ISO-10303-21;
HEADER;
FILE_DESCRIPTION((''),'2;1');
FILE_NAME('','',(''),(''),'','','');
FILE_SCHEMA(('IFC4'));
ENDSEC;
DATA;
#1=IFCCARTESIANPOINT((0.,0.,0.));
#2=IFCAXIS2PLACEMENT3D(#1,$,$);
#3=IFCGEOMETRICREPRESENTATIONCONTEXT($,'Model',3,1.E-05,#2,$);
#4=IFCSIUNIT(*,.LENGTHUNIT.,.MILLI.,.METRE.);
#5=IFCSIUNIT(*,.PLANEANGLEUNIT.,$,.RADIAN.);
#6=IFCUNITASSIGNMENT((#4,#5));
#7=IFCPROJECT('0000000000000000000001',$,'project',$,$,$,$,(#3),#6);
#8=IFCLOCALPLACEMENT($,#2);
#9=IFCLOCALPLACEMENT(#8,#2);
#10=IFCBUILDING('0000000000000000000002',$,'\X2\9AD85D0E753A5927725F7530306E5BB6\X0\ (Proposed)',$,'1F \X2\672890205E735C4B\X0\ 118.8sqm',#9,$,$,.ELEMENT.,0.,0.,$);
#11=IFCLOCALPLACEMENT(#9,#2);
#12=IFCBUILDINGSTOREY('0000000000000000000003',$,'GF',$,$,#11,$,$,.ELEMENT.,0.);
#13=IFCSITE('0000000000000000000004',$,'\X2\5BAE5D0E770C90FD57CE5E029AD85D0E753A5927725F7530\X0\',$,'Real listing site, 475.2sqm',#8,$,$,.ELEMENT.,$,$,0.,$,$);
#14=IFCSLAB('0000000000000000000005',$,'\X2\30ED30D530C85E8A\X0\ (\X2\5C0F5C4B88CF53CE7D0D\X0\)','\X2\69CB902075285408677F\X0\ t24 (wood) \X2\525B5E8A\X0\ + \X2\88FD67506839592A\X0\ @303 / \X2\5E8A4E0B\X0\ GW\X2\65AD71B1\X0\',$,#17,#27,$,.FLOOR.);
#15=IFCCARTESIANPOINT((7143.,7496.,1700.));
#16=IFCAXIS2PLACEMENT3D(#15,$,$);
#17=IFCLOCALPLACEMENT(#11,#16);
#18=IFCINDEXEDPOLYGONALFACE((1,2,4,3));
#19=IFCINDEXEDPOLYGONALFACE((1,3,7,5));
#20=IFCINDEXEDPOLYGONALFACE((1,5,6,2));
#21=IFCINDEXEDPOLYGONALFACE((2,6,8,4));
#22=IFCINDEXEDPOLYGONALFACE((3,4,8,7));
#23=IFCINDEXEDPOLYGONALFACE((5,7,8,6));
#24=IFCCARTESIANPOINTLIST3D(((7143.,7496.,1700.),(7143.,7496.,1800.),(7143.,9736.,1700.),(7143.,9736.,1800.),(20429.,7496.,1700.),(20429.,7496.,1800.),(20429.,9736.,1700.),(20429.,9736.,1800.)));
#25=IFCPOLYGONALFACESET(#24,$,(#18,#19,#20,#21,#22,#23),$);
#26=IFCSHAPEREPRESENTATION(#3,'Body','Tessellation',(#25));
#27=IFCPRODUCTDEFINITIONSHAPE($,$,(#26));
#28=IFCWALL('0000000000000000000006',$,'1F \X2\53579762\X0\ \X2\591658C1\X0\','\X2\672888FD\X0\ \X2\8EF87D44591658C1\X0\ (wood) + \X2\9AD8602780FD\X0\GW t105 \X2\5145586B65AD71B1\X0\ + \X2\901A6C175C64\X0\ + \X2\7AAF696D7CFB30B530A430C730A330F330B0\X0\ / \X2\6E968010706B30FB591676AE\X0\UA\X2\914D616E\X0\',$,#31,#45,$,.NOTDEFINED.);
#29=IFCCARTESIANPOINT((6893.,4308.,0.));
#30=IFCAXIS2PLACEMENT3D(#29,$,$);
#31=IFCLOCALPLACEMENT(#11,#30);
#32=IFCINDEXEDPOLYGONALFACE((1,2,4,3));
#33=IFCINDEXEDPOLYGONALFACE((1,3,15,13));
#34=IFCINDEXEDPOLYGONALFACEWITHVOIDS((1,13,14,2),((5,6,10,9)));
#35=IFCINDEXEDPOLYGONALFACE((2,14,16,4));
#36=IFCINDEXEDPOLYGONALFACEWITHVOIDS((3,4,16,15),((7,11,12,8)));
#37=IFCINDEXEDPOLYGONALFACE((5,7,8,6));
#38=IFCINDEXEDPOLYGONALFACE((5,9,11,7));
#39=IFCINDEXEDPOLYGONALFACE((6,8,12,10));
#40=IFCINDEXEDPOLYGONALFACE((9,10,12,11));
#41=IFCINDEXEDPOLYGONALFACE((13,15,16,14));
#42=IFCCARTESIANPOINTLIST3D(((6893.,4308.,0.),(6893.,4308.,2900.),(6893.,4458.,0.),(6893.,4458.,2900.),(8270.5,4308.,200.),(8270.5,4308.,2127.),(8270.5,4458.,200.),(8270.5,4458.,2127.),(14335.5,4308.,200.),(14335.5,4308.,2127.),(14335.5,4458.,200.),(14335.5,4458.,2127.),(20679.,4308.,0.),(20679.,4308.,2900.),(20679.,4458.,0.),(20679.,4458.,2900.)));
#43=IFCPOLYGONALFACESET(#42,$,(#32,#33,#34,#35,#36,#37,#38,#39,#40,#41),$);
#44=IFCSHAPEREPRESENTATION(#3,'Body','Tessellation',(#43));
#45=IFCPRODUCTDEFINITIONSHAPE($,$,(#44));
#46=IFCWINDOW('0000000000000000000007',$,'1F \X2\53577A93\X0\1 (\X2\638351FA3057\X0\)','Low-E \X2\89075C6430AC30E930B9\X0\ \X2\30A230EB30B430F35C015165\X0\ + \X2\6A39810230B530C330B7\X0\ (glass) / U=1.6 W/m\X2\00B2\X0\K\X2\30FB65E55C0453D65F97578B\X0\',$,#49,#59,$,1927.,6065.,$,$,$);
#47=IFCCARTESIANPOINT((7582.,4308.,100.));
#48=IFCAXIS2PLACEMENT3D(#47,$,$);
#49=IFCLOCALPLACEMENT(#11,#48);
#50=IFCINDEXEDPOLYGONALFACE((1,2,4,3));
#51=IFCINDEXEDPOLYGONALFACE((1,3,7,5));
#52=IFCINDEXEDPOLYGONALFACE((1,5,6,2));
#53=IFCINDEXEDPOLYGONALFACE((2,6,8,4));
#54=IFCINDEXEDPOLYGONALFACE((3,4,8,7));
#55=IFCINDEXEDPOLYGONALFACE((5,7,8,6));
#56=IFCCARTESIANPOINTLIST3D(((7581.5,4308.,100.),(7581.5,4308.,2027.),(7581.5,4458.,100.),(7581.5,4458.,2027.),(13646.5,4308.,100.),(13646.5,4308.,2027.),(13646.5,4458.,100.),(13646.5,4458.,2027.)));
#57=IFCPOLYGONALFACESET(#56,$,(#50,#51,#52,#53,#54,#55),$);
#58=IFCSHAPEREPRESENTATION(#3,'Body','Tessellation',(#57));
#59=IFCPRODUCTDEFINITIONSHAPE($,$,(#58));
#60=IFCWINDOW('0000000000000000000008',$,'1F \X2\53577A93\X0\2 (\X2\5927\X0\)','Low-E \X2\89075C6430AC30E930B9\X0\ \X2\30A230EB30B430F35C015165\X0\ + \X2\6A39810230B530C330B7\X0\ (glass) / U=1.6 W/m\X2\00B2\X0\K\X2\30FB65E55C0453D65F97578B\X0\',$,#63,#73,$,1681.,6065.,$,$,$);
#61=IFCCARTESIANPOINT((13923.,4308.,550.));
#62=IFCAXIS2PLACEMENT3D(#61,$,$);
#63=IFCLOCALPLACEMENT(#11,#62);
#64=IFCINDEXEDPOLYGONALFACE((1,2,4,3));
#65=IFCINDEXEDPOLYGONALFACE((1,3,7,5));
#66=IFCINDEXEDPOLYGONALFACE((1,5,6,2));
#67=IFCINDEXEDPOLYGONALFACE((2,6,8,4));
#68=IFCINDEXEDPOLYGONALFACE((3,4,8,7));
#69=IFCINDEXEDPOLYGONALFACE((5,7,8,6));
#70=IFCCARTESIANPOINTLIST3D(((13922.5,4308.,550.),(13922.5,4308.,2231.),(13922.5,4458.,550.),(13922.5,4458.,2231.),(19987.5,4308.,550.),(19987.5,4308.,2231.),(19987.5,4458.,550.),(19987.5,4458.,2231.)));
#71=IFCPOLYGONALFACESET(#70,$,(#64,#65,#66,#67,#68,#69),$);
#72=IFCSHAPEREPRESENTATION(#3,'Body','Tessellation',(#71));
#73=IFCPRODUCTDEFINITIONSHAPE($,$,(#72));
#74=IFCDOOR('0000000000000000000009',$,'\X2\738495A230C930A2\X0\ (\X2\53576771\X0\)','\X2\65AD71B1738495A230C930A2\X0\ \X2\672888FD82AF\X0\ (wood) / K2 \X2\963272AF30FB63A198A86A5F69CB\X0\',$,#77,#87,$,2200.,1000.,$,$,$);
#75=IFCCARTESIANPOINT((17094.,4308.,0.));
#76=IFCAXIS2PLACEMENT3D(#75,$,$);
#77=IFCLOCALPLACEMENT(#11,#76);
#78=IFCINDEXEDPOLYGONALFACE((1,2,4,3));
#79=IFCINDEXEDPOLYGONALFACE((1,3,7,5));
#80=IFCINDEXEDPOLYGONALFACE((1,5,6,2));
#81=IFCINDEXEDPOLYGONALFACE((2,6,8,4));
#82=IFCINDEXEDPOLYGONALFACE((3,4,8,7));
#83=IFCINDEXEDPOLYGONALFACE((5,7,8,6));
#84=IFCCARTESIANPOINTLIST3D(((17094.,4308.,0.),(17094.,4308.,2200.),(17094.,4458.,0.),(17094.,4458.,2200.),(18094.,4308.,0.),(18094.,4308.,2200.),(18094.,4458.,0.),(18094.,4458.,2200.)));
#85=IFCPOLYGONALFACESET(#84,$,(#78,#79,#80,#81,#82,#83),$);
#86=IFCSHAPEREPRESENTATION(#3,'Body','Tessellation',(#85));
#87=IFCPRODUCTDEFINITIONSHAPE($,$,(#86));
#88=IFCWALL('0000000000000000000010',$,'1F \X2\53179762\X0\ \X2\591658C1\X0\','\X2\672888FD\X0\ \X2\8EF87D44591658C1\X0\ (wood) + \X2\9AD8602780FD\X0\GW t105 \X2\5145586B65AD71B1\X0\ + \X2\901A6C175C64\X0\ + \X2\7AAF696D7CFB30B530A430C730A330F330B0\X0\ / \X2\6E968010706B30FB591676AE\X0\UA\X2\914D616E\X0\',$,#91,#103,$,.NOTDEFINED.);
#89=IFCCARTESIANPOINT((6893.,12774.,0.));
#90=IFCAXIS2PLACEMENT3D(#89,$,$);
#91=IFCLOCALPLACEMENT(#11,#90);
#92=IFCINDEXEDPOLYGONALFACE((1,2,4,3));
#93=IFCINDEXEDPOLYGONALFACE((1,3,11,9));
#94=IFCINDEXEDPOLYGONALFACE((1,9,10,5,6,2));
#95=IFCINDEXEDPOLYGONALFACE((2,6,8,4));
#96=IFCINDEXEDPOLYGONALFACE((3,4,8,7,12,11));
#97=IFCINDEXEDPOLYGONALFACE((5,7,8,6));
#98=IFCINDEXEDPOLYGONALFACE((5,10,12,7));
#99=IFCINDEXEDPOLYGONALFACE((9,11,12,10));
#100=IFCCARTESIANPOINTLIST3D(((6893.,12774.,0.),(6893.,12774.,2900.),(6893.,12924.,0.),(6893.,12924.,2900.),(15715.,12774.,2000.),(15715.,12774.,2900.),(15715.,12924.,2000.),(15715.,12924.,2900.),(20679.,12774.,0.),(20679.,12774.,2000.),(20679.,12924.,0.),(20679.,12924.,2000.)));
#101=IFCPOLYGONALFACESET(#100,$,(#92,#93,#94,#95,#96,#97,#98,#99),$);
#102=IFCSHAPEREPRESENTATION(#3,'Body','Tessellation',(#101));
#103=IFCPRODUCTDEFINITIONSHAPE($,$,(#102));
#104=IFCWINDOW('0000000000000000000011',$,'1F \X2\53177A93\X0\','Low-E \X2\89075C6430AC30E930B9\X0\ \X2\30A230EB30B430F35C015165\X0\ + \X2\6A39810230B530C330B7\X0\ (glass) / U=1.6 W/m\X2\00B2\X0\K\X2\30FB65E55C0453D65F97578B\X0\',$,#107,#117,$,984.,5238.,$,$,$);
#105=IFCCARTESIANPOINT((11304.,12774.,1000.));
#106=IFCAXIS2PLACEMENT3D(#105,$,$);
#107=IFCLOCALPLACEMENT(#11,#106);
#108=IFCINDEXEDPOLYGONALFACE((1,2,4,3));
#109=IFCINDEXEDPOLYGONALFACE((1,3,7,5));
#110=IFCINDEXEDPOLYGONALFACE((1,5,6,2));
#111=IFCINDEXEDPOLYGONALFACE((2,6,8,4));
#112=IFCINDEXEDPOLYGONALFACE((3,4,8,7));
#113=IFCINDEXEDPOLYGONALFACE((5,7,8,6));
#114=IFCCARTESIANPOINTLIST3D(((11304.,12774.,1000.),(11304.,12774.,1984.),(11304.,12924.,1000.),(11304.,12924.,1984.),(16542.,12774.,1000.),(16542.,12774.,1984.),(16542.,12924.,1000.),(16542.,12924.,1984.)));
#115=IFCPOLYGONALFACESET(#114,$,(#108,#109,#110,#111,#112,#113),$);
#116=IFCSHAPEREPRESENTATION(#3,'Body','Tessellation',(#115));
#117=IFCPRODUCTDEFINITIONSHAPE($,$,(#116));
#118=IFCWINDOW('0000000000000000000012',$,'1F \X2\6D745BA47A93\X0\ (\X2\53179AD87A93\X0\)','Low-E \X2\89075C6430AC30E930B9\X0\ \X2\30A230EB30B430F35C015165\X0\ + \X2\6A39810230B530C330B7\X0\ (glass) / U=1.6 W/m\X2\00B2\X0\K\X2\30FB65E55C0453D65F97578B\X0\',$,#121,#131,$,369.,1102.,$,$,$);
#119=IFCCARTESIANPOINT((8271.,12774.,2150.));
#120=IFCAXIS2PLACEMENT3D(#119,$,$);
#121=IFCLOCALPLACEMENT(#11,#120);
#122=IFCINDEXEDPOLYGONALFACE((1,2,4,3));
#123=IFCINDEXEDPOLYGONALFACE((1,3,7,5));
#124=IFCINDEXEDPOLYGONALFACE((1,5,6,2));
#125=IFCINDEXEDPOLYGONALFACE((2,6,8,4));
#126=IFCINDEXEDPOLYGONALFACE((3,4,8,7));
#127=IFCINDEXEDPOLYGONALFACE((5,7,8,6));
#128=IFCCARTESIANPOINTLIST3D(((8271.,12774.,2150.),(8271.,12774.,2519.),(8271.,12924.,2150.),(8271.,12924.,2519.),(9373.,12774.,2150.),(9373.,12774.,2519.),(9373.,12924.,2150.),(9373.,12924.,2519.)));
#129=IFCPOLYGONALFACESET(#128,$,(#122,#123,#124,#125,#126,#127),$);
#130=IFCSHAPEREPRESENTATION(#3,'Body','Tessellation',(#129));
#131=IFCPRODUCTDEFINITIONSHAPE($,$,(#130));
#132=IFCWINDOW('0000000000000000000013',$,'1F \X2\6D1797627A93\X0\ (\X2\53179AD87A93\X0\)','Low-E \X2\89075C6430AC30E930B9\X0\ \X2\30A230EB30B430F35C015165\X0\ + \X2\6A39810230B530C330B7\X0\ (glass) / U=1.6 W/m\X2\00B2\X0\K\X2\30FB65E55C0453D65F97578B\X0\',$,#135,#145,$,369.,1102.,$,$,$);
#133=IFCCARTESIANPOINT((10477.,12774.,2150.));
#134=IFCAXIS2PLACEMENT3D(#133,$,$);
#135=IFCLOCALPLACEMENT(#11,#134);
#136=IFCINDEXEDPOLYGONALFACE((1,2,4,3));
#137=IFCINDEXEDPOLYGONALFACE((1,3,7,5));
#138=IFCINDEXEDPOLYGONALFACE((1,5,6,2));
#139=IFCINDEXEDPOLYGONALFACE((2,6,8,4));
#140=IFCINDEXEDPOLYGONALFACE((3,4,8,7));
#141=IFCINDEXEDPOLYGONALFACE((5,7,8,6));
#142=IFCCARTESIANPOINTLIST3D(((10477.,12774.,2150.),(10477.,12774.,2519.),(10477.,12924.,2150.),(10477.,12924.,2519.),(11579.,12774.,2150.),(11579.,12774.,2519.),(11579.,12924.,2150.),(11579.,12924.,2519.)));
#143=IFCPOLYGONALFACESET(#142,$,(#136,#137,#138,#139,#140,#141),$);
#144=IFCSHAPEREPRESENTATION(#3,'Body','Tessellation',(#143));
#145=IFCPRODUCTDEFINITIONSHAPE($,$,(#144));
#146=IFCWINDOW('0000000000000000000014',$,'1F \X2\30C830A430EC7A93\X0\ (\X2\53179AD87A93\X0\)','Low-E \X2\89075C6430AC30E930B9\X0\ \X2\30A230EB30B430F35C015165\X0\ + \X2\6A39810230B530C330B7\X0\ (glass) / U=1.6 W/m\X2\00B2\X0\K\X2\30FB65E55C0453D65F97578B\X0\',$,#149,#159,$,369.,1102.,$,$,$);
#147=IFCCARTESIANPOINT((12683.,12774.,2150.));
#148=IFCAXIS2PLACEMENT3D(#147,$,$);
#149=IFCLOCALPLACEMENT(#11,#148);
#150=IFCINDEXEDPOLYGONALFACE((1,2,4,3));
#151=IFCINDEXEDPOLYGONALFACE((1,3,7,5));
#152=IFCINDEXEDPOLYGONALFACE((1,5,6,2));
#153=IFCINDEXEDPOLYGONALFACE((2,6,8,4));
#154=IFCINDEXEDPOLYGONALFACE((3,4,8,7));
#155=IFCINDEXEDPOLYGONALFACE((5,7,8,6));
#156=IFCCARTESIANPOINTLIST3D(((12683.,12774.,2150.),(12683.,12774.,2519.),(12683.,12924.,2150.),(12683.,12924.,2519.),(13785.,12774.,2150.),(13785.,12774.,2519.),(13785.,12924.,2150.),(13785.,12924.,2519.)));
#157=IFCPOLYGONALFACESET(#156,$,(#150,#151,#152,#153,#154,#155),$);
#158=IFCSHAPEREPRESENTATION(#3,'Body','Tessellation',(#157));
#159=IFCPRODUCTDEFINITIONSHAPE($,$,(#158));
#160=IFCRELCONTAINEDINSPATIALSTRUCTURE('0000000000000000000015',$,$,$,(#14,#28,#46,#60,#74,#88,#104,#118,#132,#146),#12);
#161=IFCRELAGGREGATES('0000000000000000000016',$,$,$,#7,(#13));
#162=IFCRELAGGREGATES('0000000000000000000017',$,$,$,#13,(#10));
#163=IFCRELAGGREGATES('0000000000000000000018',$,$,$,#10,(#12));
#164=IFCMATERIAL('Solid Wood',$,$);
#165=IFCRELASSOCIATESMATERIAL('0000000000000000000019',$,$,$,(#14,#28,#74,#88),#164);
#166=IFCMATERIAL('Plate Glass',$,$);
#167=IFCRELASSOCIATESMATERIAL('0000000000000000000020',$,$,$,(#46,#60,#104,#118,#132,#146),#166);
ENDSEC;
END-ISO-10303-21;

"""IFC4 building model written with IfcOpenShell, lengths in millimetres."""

from ifc_helpers import new_model, si_unit, frame, frame_2d, origin, place, context, project, spatial, rectangle, extrude, material, element, fill, save


model = new_model("IFC4")

# Units and contexts
model_context = context("Model", 3, precision=1e-05, world=origin())
ifc_project = project(units=[si_unit("LENGTHUNIT", "METRE", prefix="MILLI"), si_unit("PLANEANGLEUNIT", "RADIAN")], contexts=[model_context])

# Site, building, storey
site_placement = place(None, origin())
site = spatial("IfcSite", under=ifc_project, at=site_placement, Name="宮崎県都城市高崎町大牟田", ObjectType="Real listing site, 475.2sqm", CompositionType="ELEMENT", RefElevation=0.0)
building_placement = place(site_placement, origin())
building = spatial("IfcBuilding", under=site, at=building_placement, Name="高崎町大牟田の家 (Proposed)", ObjectType="1F 木造平屋 118.8sqm", CompositionType="ELEMENT", ElevationOfRefHeight=0.0, ElevationOfTerrain=0.0)
storey_placement = place(building_placement, origin())
storey = spatial("IfcBuildingStorey", under=building, at=storey_placement, Name="GF", CompositionType="ELEMENT", Elevation=0.0)

# Slab
ifc_material_1 = material(Name="Solid Wood")
slab_1_placement = place(storey_placement, frame((7143.0, 7496.0, 1700.0)))
element("IfcSlab", 1, at=slab_1_placement, inside=storey, material=ifc_material_1, Name="ロフト床 (小屋裏収納)", Description="構造用合板 t24 (wood) 剛床 + 製材根太 @303 / 床下 GW断熱", PredefinedType="FLOOR", context=model_context, shape_type="SweptSolid", body=[
    extrude(rectangle(XDim=13286.0, YDim=2240.0, at=frame_2d((6643.0, 1120.0))), frame((7143.0, 7496.0, 1700.0)), (0.0, 0.0, 1.0), 100.0),
])

# Wall, openings, windows, door
wall_1_placement = place(storey_placement, frame((6893.0, 4308.0, 0.0)))
wall_1 = element("IfcWall", 2, at=wall_1_placement, inside=storey, material=ifc_material_1, Name="1F 南面 外壁", Description="木製 軸組外壁 (wood) + 高性能GW t105 充填断熱 + 通気層 + 窯業系サイディング / 準耐火・外皮UA配慮", PredefinedType="NOTDEFINED", context=model_context, shape_type="SweptSolid", body=[
    extrude(rectangle(XDim=13786.0, YDim=150.0, at=frame_2d((6893.0, 75.0))), frame((6893.0, 4308.0, 0.0)), (0.0, 0.0, 1.0), 2900.0),
])
opening_1_placement = place(storey_placement, frame((7582.0, 4308.0, 100.0)))
opening_1 = element("IfcOpeningElement", 3, at=opening_1_placement, cuts=wall_1, PredefinedType="NOTDEFINED", context=model_context, shape_type="SweptSolid", body=[
    extrude(rectangle(XDim=6065.0, YDim=150.0, at=frame_2d((3032.0, 75.0))), frame((7582.0, 4308.0, 100.0)), (0.0, 0.0, 1.0), 1927.0),
])
opening_2_placement = place(storey_placement, frame((13923.0, 4308.0, 550.0)))
opening_2 = element("IfcOpeningElement", 4, at=opening_2_placement, cuts=wall_1, PredefinedType="NOTDEFINED", context=model_context, shape_type="SweptSolid", body=[
    extrude(rectangle(XDim=6065.0, YDim=150.0, at=frame_2d((3032.0, 75.0))), frame((13923.0, 4308.0, 550.0)), (0.0, 0.0, 1.0), 1681.0),
])
opening_3_placement = place(storey_placement, frame((17094.0, 4308.0, 0.0)))
opening_3 = element("IfcOpeningElement", 5, at=opening_3_placement, cuts=wall_1, PredefinedType="NOTDEFINED", context=model_context, shape_type="SweptSolid", body=[
    extrude(rectangle(XDim=1000.0, YDim=150.0, at=frame_2d((500.0, 75.0))), frame((17094.0, 4308.0, 0.0)), (0.0, 0.0, 1.0), 2200.0),
])
ifc_material_2 = material(Name="Plate Glass")
window_1_placement = place(storey_placement, frame((7582.0, 4308.0, 100.0)))
window_1 = element("IfcWindow", 6, at=window_1_placement, inside=storey, material=ifc_material_2, Name="1F 南窓1 (掃出し)", Description="Low-E 複層ガラス アルゴン封入 + 樹脂サッシ (glass) / U=1.6 W/m²K・日射取得型", OverallHeight=1927.0, OverallWidth=6065.0, context=model_context, shape_type="SweptSolid", body=[
    extrude(rectangle(XDim=6065.0, YDim=150.0, at=frame_2d((3032.0, 75.0))), frame((7582.0, 4308.0, 100.0)), (0.0, 0.0, 1.0), 1927.0),
])
fill(opening_1, window_1)
window_2_placement = place(storey_placement, frame((13923.0, 4308.0, 550.0)))
window_2 = element("IfcWindow", 7, at=window_2_placement, inside=storey, material=ifc_material_2, Name="1F 南窓2 (大)", Description="Low-E 複層ガラス アルゴン封入 + 樹脂サッシ (glass) / U=1.6 W/m²K・日射取得型", OverallHeight=1681.0, OverallWidth=6065.0, context=model_context, shape_type="SweptSolid", body=[
    extrude(rectangle(XDim=6065.0, YDim=150.0, at=frame_2d((3032.0, 75.0))), frame((13923.0, 4308.0, 550.0)), (0.0, 0.0, 1.0), 1681.0),
])
fill(opening_2, window_2)
door_1_placement = place(storey_placement, frame((17094.0, 4308.0, 0.0)))
door_1 = element("IfcDoor", 8, at=door_1_placement, inside=storey, material=ifc_material_1, Name="玄関ドア (南東)", Description="断熱玄関ドア 木製芯 (wood) / K2 防犯・採風機構", OverallHeight=2200.0, OverallWidth=1000.0, context=model_context, shape_type="SweptSolid", body=[
    extrude(rectangle(XDim=1000.0, YDim=150.0, at=frame_2d((500.0, 75.0))), frame((17094.0, 4308.0, 0.0)), (0.0, 0.0, 1.0), 2200.0),
])
fill(opening_3, door_1)

# Wall, openings, windows
wall_2_placement = place(storey_placement, frame((6893.0, 12774.0, 0.0)))
wall_2 = element("IfcWall", 9, at=wall_2_placement, inside=storey, material=ifc_material_1, Name="1F 北面 外壁", Description="木製 軸組外壁 (wood) + 高性能GW t105 充填断熱 + 通気層 + 窯業系サイディング / 準耐火・外皮UA配慮", PredefinedType="NOTDEFINED", context=model_context, shape_type="SweptSolid", body=[
    extrude(rectangle(XDim=13786.0, YDim=150.0, at=frame_2d((6893.0, 75.0))), frame((6893.0, 12774.0, 0.0)), (0.0, 0.0, 1.0), 2900.0),
])
opening_4_placement = place(storey_placement, frame((11304.0, 12774.0, 1000.0)))
opening_4 = element("IfcOpeningElement", 10, at=opening_4_placement, cuts=wall_2, PredefinedType="NOTDEFINED", context=model_context, shape_type="SweptSolid", body=[
    extrude(rectangle(XDim=5238.0, YDim=150.0, at=frame_2d((2619.0, 75.0))), frame((11304.0, 12774.0, 1000.0)), (0.0, 0.0, 1.0), 984.0),
])
opening_5_placement = place(storey_placement, frame((8271.0, 12774.0, 2150.0)))
opening_5 = element("IfcOpeningElement", 11, at=opening_5_placement, cuts=wall_2, PredefinedType="NOTDEFINED", context=model_context, shape_type="SweptSolid", body=[
    extrude(rectangle(XDim=1102.0, YDim=150.0, at=frame_2d((551.0, 75.0))), frame((8271.0, 12774.0, 2150.0)), (0.0, 0.0, 1.0), 369.0),
])
opening_6_placement = place(storey_placement, frame((10477.0, 12774.0, 2150.0)))
opening_6 = element("IfcOpeningElement", 12, at=opening_6_placement, cuts=wall_2, PredefinedType="NOTDEFINED", context=model_context, shape_type="SweptSolid", body=[
    extrude(rectangle(XDim=1102.0, YDim=150.0, at=frame_2d((551.0, 75.0))), frame((10477.0, 12774.0, 2150.0)), (0.0, 0.0, 1.0), 369.0),
])
opening_7_placement = place(storey_placement, frame((12683.0, 12774.0, 2150.0)))
opening_7 = element("IfcOpeningElement", 13, at=opening_7_placement, cuts=wall_2, PredefinedType="NOTDEFINED", context=model_context, shape_type="SweptSolid", body=[
    extrude(rectangle(XDim=1102.0, YDim=150.0, at=frame_2d((551.0, 75.0))), frame((12683.0, 12774.0, 2150.0)), (0.0, 0.0, 1.0), 369.0),
])
window_3_placement = place(storey_placement, frame((11304.0, 12774.0, 1000.0)))
window_3 = element("IfcWindow", 14, at=window_3_placement, inside=storey, material=ifc_material_2, Name="1F 北窓", Description="Low-E 複層ガラス アルゴン封入 + 樹脂サッシ (glass) / U=1.6 W/m²K・日射取得型", OverallHeight=984.0, OverallWidth=5238.0, context=model_context, shape_type="SweptSolid", body=[
    extrude(rectangle(XDim=5238.0, YDim=150.0, at=frame_2d((2619.0, 75.0))), frame((11304.0, 12774.0, 1000.0)), (0.0, 0.0, 1.0), 984.0),
])
fill(opening_4, window_3)
window_4_placement = place(storey_placement, frame((8271.0, 12774.0, 2150.0)))
window_4 = element("IfcWindow", 15, at=window_4_placement, inside=storey, material=ifc_material_2, Name="1F 浴室窓 (北高窓)", Description="Low-E 複層ガラス アルゴン封入 + 樹脂サッシ (glass) / U=1.6 W/m²K・日射取得型", OverallHeight=369.0, OverallWidth=1102.0, context=model_context, shape_type="SweptSolid", body=[
    extrude(rectangle(XDim=1102.0, YDim=150.0, at=frame_2d((551.0, 75.0))), frame((8271.0, 12774.0, 2150.0)), (0.0, 0.0, 1.0), 369.0),
])
fill(opening_5, window_4)
window_5_placement = place(storey_placement, frame((10477.0, 12774.0, 2150.0)))
window_5 = element("IfcWindow", 16, at=window_5_placement, inside=storey, material=ifc_material_2, Name="1F 洗面窓 (北高窓)", Description="Low-E 複層ガラス アルゴン封入 + 樹脂サッシ (glass) / U=1.6 W/m²K・日射取得型", OverallHeight=369.0, OverallWidth=1102.0, context=model_context, shape_type="SweptSolid", body=[
    extrude(rectangle(XDim=1102.0, YDim=150.0, at=frame_2d((551.0, 75.0))), frame((10477.0, 12774.0, 2150.0)), (0.0, 0.0, 1.0), 369.0),
])
fill(opening_6, window_5)
window_6_placement = place(storey_placement, frame((12683.0, 12774.0, 2150.0)))
window_6 = element("IfcWindow", 17, at=window_6_placement, inside=storey, material=ifc_material_2, Name="1F トイレ窓 (北高窓)", Description="Low-E 複層ガラス アルゴン封入 + 樹脂サッシ (glass) / U=1.6 W/m²K・日射取得型", OverallHeight=369.0, OverallWidth=1102.0, context=model_context, shape_type="SweptSolid", body=[
    extrude(rectangle(XDim=1102.0, YDim=150.0, at=frame_2d((551.0, 75.0))), frame((12683.0, 12774.0, 2150.0)), (0.0, 0.0, 1.0), 369.0),
])
fill(opening_7, window_6)

save(model, "model.ifc")
